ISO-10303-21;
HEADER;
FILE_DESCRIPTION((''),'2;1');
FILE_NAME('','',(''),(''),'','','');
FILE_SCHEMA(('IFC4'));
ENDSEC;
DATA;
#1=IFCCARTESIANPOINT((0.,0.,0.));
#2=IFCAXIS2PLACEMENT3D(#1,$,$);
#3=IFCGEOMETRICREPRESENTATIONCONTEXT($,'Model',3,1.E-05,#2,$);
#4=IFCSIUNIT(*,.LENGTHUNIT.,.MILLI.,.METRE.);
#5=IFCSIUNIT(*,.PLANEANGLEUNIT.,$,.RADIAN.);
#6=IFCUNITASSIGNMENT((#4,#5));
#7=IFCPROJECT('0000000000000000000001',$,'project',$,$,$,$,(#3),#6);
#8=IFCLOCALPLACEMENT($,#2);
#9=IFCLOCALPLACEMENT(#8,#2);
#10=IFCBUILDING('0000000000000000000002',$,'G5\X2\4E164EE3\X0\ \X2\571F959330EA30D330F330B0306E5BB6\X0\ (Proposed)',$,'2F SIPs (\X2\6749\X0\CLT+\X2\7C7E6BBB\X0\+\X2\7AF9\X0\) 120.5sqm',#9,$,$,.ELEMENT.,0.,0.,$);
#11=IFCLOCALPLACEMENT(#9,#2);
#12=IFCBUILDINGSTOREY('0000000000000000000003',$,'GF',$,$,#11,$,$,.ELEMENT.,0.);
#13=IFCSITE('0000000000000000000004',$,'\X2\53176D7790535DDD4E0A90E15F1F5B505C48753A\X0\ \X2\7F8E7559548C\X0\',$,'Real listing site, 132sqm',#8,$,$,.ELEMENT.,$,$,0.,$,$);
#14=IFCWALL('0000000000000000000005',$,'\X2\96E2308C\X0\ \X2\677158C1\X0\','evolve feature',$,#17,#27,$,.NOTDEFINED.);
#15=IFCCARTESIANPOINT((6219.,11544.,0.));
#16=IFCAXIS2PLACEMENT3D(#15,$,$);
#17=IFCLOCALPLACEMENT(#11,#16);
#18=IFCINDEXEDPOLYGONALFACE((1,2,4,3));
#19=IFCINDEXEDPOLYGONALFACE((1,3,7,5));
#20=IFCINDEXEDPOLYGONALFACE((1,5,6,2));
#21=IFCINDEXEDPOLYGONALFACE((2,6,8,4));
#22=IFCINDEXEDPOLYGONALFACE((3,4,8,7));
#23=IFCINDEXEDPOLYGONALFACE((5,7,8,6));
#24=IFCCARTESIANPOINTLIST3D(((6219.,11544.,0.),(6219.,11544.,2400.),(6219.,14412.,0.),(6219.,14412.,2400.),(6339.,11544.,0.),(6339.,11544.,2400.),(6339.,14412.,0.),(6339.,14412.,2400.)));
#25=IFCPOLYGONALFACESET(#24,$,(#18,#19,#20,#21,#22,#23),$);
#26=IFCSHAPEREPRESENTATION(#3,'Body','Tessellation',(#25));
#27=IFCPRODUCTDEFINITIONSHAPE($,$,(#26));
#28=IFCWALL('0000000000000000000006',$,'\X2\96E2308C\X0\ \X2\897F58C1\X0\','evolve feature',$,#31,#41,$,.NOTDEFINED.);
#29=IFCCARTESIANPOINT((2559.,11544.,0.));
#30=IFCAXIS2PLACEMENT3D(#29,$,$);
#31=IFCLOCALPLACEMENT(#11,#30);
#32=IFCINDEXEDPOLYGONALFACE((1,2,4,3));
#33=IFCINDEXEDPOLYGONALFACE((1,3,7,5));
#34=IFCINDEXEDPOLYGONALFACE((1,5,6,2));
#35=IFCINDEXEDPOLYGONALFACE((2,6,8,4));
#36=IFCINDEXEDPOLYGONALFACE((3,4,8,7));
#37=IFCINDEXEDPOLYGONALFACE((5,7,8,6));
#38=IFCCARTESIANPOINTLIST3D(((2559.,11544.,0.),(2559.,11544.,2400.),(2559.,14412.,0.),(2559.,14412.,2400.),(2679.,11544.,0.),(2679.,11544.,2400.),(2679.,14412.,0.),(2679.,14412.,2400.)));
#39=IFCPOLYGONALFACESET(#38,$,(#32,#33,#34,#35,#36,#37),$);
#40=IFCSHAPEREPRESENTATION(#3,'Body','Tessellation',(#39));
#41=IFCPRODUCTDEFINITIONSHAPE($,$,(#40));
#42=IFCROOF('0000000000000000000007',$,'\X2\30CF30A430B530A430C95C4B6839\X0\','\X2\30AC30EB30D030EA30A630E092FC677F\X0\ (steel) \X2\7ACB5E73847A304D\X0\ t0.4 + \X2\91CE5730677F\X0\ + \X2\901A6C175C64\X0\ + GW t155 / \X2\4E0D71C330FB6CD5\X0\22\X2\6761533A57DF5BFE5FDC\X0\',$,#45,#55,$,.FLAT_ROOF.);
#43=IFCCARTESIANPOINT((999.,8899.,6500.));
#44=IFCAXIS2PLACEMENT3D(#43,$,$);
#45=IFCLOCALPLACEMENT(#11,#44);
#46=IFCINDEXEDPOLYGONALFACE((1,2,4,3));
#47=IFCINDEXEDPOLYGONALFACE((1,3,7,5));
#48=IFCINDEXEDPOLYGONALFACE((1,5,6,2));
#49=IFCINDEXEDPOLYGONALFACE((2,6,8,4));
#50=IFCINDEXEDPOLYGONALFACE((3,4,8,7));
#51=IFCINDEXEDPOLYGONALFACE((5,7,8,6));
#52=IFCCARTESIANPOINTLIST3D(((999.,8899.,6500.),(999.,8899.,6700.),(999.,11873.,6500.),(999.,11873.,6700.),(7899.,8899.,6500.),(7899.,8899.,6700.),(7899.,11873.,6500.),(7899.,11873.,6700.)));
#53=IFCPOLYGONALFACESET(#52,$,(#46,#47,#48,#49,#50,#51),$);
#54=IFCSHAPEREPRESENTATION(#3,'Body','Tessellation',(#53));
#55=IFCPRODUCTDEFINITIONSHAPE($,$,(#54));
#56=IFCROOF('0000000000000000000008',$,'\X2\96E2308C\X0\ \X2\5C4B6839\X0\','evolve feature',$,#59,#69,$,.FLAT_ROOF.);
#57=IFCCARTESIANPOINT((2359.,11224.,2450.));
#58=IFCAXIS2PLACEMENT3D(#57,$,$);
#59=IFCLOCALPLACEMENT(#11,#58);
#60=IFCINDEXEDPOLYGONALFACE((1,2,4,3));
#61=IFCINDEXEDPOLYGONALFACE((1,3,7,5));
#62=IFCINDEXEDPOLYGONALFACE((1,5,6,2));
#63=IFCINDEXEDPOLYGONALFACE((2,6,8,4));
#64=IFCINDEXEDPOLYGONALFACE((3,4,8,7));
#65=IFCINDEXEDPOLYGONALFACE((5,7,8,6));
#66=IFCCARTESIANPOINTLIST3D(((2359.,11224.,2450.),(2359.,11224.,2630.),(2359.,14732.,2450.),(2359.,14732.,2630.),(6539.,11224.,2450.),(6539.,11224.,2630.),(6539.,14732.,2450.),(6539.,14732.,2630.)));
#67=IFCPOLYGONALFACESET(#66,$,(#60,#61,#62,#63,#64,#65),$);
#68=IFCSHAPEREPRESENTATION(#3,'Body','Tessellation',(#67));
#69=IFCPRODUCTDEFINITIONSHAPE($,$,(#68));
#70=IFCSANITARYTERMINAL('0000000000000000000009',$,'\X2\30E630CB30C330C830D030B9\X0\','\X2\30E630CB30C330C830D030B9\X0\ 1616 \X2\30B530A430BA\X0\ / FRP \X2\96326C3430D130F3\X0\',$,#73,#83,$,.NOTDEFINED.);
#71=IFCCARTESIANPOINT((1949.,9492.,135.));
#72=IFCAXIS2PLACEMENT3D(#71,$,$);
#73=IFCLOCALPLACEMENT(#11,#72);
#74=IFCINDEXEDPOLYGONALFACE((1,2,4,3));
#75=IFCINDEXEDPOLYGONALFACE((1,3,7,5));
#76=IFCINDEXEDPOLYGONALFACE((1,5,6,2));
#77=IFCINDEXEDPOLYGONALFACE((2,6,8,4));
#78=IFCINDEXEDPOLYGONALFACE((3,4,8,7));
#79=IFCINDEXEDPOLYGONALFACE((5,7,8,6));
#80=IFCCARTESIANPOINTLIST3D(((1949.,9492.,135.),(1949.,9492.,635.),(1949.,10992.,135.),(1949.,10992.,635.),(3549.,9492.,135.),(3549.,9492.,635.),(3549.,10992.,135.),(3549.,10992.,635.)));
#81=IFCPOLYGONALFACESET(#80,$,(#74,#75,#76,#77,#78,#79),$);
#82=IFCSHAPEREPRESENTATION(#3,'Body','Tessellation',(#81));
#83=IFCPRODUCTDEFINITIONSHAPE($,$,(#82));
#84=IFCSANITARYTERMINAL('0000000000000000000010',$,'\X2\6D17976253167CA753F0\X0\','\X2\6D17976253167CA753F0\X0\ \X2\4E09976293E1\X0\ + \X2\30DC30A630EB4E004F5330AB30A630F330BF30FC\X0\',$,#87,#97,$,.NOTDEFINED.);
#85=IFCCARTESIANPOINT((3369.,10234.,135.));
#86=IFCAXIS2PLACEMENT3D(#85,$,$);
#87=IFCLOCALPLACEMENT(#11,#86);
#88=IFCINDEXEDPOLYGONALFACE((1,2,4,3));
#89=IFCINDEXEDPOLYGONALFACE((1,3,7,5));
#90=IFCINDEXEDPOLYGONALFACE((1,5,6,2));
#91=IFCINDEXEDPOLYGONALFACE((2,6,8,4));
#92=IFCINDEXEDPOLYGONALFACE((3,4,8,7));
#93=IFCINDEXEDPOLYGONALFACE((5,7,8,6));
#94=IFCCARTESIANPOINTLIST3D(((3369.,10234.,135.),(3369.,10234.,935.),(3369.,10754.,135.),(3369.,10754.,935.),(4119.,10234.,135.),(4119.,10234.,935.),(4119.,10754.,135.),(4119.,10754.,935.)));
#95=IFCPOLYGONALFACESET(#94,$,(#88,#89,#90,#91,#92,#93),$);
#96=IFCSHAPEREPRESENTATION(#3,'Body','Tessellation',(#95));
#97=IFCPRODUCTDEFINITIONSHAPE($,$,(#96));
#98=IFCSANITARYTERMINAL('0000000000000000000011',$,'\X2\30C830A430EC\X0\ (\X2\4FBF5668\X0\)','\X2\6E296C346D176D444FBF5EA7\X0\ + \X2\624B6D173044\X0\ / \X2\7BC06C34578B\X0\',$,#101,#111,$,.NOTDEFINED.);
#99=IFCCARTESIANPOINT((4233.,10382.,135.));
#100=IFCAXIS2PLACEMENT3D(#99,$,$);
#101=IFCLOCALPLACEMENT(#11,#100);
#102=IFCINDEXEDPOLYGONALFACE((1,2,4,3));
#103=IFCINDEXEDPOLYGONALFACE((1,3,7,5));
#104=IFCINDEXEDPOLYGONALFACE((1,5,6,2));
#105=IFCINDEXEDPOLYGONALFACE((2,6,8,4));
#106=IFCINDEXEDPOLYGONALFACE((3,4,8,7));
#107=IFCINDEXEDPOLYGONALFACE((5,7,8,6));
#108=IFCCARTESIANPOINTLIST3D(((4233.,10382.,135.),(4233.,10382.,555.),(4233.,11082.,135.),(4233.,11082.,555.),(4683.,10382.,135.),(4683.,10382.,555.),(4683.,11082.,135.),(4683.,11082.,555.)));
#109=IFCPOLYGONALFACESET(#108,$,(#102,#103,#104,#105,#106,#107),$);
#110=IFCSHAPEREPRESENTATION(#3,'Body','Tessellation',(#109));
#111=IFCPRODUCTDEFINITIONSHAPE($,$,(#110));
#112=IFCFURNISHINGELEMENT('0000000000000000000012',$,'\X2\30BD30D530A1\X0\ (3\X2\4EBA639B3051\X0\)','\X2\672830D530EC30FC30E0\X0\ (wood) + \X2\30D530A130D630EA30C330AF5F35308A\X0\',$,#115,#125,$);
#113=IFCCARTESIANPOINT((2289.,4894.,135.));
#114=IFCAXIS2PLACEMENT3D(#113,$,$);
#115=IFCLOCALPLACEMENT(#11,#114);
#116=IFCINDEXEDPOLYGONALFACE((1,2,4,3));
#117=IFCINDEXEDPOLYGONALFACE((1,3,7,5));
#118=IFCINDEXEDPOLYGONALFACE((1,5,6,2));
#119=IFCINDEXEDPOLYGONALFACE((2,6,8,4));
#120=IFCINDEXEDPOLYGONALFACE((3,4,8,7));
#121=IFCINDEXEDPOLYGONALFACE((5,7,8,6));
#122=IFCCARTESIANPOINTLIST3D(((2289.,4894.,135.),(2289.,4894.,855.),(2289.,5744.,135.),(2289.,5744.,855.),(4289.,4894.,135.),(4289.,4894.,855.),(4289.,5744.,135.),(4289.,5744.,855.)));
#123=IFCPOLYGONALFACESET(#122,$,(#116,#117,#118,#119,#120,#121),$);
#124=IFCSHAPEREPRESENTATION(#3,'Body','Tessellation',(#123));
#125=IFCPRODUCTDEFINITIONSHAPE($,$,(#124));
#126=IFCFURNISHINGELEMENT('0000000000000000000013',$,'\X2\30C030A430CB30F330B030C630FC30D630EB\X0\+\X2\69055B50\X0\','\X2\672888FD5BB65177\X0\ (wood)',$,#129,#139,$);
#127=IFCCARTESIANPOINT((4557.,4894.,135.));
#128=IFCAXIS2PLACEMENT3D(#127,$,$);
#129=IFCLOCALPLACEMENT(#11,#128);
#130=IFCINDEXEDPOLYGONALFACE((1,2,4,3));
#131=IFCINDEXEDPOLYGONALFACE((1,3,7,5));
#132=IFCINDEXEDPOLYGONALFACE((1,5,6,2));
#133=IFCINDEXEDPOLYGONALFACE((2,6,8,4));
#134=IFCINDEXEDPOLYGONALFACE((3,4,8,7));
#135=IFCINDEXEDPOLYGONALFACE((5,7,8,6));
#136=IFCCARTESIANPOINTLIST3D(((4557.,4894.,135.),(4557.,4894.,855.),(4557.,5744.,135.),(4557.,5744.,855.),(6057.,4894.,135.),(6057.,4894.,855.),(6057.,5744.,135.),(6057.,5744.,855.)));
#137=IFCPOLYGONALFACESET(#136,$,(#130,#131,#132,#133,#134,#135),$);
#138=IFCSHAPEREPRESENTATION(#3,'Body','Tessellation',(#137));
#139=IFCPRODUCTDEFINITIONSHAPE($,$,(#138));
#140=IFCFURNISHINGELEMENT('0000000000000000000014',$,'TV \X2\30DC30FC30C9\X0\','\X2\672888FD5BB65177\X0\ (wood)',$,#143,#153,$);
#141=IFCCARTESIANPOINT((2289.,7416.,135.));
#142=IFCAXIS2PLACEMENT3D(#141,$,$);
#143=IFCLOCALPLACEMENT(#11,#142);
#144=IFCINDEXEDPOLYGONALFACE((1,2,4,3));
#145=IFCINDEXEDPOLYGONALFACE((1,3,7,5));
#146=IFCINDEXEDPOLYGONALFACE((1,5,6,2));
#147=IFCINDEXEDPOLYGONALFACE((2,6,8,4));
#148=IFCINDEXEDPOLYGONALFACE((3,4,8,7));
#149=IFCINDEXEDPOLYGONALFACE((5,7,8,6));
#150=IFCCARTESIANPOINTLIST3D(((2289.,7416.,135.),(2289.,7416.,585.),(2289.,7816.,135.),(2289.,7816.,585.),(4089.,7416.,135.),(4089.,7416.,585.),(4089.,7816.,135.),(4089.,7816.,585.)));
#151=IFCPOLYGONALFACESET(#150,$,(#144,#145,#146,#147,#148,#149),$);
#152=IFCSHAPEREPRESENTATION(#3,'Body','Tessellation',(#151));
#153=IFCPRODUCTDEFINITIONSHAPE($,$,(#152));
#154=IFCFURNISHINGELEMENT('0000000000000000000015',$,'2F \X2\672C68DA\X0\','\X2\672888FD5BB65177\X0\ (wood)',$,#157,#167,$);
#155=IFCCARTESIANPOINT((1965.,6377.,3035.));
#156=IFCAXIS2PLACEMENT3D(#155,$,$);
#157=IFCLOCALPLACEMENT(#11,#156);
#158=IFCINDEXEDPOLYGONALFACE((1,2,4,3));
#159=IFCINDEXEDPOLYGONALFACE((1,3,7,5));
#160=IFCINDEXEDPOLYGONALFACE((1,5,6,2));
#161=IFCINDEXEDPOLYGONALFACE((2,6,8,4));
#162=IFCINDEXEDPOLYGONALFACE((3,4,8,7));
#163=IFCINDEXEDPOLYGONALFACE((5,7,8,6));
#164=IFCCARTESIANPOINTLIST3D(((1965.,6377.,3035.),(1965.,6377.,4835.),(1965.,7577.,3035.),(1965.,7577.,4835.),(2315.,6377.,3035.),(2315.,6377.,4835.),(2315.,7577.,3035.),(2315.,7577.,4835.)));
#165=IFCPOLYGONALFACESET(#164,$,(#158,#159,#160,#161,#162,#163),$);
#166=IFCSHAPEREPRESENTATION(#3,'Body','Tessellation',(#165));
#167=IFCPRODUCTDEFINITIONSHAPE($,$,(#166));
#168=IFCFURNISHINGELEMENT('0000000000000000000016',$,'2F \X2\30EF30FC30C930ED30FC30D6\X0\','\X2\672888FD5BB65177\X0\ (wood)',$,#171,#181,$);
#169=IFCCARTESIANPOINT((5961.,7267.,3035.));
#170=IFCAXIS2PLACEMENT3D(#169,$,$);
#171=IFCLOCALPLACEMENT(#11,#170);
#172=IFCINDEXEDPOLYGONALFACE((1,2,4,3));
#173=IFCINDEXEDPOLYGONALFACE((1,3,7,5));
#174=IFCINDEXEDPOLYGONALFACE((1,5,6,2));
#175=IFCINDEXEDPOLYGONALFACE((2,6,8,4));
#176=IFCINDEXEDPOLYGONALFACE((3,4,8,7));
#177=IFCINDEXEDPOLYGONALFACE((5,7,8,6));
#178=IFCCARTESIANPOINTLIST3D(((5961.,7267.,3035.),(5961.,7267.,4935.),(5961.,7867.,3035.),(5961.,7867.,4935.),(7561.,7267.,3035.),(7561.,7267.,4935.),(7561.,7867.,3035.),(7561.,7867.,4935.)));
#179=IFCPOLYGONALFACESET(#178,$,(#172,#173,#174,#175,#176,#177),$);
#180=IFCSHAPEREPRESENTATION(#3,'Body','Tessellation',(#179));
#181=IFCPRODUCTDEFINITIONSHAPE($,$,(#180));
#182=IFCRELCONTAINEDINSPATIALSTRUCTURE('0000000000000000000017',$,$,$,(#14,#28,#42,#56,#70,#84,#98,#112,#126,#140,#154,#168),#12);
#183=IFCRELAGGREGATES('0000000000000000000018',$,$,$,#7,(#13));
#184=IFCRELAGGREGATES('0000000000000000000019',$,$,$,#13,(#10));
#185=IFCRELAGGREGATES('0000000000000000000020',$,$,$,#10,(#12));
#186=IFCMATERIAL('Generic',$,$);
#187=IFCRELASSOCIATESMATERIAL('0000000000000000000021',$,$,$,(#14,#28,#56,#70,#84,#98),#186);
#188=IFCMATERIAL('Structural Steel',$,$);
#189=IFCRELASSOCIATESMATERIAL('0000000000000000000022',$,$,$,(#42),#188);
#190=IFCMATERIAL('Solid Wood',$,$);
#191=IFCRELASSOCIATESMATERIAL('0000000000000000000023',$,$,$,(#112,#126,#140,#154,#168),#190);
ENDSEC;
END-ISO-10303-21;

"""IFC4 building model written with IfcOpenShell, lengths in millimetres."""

from ifc_helpers import new_model, si_unit, frame, frame_2d, origin, place, context, project, spatial, rectangle, extrude, material, element, save


model = new_model("IFC4")

# Units and contexts
model_context = context("Model", 3, precision=1e-05, world=origin())
ifc_project = project(units=[si_unit("LENGTHUNIT", "METRE", prefix="MILLI"), si_unit("PLANEANGLEUNIT", "RADIAN")], contexts=[model_context])

# Site, building, storey
site_placement = place(None, origin())
site = spatial("IfcSite", under=ifc_project, at=site_placement, Name="北海道川上郡弟子屈町 美留和", ObjectType="Real listing site, 132sqm", CompositionType="ELEMENT", RefElevation=0.0)
building_placement = place(site_placement, origin())
building = spatial("IfcBuilding", under=site, at=building_placement, Name="G5世代 土間リビングの家 (Proposed)", ObjectType="2F SIPs (杉CLT+籾殻+竹) 120.5sqm", CompositionType="ELEMENT", ElevationOfRefHeight=0.0, ElevationOfTerrain=0.0)
storey_placement = place(building_placement, origin())
storey = spatial("IfcBuildingStorey", under=building, at=storey_placement, Name="GF", CompositionType="ELEMENT", Elevation=0.0)

# Shared definitions
ifc_material_1 = material(Name="Generic")

# Shared definitions
ifc_material_2 = material(Name="Solid Wood")

# Walls
wall_1_placement = place(storey_placement, frame((6219.0, 11544.0, 0.0)))
element("IfcWall", 1, at=wall_1_placement, inside=storey, material=ifc_material_1, Name="離れ 東壁", Description="evolve feature", PredefinedType="NOTDEFINED", context=model_context, shape_type="SweptSolid", body=[
    extrude(rectangle(XDim=120.0, YDim=2868.0, at=frame_2d((60.0, 1434.0))), frame((6219.0, 11544.0, 0.0)), (0.0, 0.0, 1.0), 2400.0),
])
wall_2_placement = place(storey_placement, frame((2559.0, 11544.0, 0.0)))
element("IfcWall", 2, at=wall_2_placement, inside=storey, material=ifc_material_1, Name="離れ 西壁", Description="evolve feature", PredefinedType="NOTDEFINED", context=model_context, shape_type="SweptSolid", body=[
    extrude(rectangle(XDim=120.0, YDim=2868.0, at=frame_2d((60.0, 1434.0))), frame((2559.0, 11544.0, 0.0)), (0.0, 0.0, 1.0), 2400.0),
])

# Roofs
ifc_material_3 = material(Name="Structural Steel")
roof_1_placement = place(storey_placement, frame((999.0, 8899.0, 6500.0)))
element("IfcRoof", 3, at=roof_1_placement, inside=storey, material=ifc_material_3, Name="ハイサイド屋根", Description="ガルバリウム鋼板 (steel) 立平葺き t0.4 + 野地板 + 通気層 + GW t155 / 不燃・法22条区域対応", PredefinedType="FLAT_ROOF", context=model_context, shape_type="SweptSolid", body=[
    extrude(rectangle(XDim=6900.0, YDim=2974.0, at=frame_2d((3450.0, 1487.0))), frame((999.0, 8899.0, 6500.0)), (0.0, 0.0, 1.0), 200.0),
])
roof_2_placement = place(storey_placement, frame((2359.0, 11224.0, 2450.0)))
element("IfcRoof", 4, at=roof_2_placement, inside=storey, material=ifc_material_1, Name="離れ 屋根", Description="evolve feature", PredefinedType="FLAT_ROOF", context=model_context, shape_type="SweptSolid", body=[
    extrude(rectangle(XDim=4180.0, YDim=3508.0, at=frame_2d((2090.0, 1754.0))), frame((2359.0, 11224.0, 2450.0)), (0.0, 0.0, 1.0), 180.0),
])

# Sanitary terminals
sanitary_terminal_1_placement = place(storey_placement, frame((1949.0, 9492.0, 135.0)))
element("IfcSanitaryTerminal", 5, at=sanitary_terminal_1_placement, inside=storey, material=ifc_material_1, Name="ユニットバス", Description="ユニットバス 1616 サイズ / FRP 防水パン", PredefinedType="NOTDEFINED", context=model_context, shape_type="SweptSolid", body=[
    extrude(rectangle(XDim=1600.0, YDim=1500.0, at=frame_2d((800.0, 750.0))), frame((1949.0, 9492.0, 135.0)), (0.0, 0.0, 1.0), 500.0),
])
sanitary_terminal_2_placement = place(storey_placement, frame((3369.0, 10234.0, 135.0)))
element("IfcSanitaryTerminal", 6, at=sanitary_terminal_2_placement, inside=storey, material=ifc_material_1, Name="洗面化粧台", Description="洗面化粧台 三面鏡 + ボウル一体カウンター", PredefinedType="NOTDEFINED", context=model_context, shape_type="SweptSolid", body=[
    extrude(rectangle(XDim=750.0, YDim=520.0, at=frame_2d((375.0, 260.0))), frame((3369.0, 10234.0, 135.0)), (0.0, 0.0, 1.0), 800.0),
])
sanitary_terminal_3_placement = place(storey_placement, frame((4233.0, 10382.0, 135.0)))
element("IfcSanitaryTerminal", 7, at=sanitary_terminal_3_placement, inside=storey, material=ifc_material_1, Name="トイレ (便器)", Description="温水洗浄便座 + 手洗い / 節水型", PredefinedType="NOTDEFINED", context=model_context, shape_type="SweptSolid", body=[
    extrude(rectangle(XDim=450.0, YDim=700.0, at=frame_2d((225.0, 350.0))), frame((4233.0, 10382.0, 135.0)), (0.0, 0.0, 1.0), 420.0),
])

# Furnishing elements
furnishing_1_placement = place(storey_placement, frame((2289.0, 4894.0, 135.0)))
element("IfcFurnishingElement", 8, at=furnishing_1_placement, inside=storey, material=ifc_material_2, Name="ソファ (3人掛け)", Description="木フレーム (wood) + ファブリック張り", context=model_context, shape_type="SweptSolid", body=[
    extrude(rectangle(XDim=2000.0, YDim=850.0, at=frame_2d((1000.0, 425.0))), frame((2289.0, 4894.0, 135.0)), (0.0, 0.0, 1.0), 720.0),
])
furnishing_2_placement = place(storey_placement, frame((4557.0, 4894.0, 135.0)))
element("IfcFurnishingElement", 9, at=furnishing_2_placement, inside=storey, material=ifc_material_2, Name="ダイニングテーブル+椅子", Description="木製家具 (wood)", context=model_context, shape_type="SweptSolid", body=[
    extrude(rectangle(XDim=1500.0, YDim=850.0, at=frame_2d((750.0, 425.0))), frame((4557.0, 4894.0, 135.0)), (0.0, 0.0, 1.0), 720.0),
])
furnishing_3_placement = place(storey_placement, frame((2289.0, 7416.0, 135.0)))
element("IfcFurnishingElement", 10, at=furnishing_3_placement, inside=storey, material=ifc_material_2, Name="TV ボード", Description="木製家具 (wood)", context=model_context, shape_type="SweptSolid", body=[
    extrude(rectangle(XDim=1800.0, YDim=400.0, at=frame_2d((900.0, 200.0))), frame((2289.0, 7416.0, 135.0)), (0.0, 0.0, 1.0), 450.0),
])
furnishing_4_placement = place(storey_placement, frame((1965.0, 6377.0, 3035.0)))
element("IfcFurnishingElement", 11, at=furnishing_4_placement, inside=storey, material=ifc_material_2, Name="2F 本棚", Description="木製家具 (wood)", context=model_context, shape_type="SweptSolid", body=[
    extrude(rectangle(XDim=350.0, YDim=1200.0, at=frame_2d((175.0, 600.0))), frame((1965.0, 6377.0, 3035.0)), (0.0, 0.0, 1.0), 1800.0),
])
furnishing_5_placement = place(storey_placement, frame((5961.0, 7267.0, 3035.0)))
element("IfcFurnishingElement", 12, at=furnishing_5_placement, inside=storey, material=ifc_material_2, Name="2F ワードローブ", Description="木製家具 (wood)", context=model_context, shape_type="SweptSolid", body=[
    extrude(rectangle(XDim=1600.0, YDim=600.0, at=frame_2d((800.0, 300.0))), frame((5961.0, 7267.0, 3035.0)), (0.0, 0.0, 1.0), 1900.0),
])

save(model, "model.ifc")
